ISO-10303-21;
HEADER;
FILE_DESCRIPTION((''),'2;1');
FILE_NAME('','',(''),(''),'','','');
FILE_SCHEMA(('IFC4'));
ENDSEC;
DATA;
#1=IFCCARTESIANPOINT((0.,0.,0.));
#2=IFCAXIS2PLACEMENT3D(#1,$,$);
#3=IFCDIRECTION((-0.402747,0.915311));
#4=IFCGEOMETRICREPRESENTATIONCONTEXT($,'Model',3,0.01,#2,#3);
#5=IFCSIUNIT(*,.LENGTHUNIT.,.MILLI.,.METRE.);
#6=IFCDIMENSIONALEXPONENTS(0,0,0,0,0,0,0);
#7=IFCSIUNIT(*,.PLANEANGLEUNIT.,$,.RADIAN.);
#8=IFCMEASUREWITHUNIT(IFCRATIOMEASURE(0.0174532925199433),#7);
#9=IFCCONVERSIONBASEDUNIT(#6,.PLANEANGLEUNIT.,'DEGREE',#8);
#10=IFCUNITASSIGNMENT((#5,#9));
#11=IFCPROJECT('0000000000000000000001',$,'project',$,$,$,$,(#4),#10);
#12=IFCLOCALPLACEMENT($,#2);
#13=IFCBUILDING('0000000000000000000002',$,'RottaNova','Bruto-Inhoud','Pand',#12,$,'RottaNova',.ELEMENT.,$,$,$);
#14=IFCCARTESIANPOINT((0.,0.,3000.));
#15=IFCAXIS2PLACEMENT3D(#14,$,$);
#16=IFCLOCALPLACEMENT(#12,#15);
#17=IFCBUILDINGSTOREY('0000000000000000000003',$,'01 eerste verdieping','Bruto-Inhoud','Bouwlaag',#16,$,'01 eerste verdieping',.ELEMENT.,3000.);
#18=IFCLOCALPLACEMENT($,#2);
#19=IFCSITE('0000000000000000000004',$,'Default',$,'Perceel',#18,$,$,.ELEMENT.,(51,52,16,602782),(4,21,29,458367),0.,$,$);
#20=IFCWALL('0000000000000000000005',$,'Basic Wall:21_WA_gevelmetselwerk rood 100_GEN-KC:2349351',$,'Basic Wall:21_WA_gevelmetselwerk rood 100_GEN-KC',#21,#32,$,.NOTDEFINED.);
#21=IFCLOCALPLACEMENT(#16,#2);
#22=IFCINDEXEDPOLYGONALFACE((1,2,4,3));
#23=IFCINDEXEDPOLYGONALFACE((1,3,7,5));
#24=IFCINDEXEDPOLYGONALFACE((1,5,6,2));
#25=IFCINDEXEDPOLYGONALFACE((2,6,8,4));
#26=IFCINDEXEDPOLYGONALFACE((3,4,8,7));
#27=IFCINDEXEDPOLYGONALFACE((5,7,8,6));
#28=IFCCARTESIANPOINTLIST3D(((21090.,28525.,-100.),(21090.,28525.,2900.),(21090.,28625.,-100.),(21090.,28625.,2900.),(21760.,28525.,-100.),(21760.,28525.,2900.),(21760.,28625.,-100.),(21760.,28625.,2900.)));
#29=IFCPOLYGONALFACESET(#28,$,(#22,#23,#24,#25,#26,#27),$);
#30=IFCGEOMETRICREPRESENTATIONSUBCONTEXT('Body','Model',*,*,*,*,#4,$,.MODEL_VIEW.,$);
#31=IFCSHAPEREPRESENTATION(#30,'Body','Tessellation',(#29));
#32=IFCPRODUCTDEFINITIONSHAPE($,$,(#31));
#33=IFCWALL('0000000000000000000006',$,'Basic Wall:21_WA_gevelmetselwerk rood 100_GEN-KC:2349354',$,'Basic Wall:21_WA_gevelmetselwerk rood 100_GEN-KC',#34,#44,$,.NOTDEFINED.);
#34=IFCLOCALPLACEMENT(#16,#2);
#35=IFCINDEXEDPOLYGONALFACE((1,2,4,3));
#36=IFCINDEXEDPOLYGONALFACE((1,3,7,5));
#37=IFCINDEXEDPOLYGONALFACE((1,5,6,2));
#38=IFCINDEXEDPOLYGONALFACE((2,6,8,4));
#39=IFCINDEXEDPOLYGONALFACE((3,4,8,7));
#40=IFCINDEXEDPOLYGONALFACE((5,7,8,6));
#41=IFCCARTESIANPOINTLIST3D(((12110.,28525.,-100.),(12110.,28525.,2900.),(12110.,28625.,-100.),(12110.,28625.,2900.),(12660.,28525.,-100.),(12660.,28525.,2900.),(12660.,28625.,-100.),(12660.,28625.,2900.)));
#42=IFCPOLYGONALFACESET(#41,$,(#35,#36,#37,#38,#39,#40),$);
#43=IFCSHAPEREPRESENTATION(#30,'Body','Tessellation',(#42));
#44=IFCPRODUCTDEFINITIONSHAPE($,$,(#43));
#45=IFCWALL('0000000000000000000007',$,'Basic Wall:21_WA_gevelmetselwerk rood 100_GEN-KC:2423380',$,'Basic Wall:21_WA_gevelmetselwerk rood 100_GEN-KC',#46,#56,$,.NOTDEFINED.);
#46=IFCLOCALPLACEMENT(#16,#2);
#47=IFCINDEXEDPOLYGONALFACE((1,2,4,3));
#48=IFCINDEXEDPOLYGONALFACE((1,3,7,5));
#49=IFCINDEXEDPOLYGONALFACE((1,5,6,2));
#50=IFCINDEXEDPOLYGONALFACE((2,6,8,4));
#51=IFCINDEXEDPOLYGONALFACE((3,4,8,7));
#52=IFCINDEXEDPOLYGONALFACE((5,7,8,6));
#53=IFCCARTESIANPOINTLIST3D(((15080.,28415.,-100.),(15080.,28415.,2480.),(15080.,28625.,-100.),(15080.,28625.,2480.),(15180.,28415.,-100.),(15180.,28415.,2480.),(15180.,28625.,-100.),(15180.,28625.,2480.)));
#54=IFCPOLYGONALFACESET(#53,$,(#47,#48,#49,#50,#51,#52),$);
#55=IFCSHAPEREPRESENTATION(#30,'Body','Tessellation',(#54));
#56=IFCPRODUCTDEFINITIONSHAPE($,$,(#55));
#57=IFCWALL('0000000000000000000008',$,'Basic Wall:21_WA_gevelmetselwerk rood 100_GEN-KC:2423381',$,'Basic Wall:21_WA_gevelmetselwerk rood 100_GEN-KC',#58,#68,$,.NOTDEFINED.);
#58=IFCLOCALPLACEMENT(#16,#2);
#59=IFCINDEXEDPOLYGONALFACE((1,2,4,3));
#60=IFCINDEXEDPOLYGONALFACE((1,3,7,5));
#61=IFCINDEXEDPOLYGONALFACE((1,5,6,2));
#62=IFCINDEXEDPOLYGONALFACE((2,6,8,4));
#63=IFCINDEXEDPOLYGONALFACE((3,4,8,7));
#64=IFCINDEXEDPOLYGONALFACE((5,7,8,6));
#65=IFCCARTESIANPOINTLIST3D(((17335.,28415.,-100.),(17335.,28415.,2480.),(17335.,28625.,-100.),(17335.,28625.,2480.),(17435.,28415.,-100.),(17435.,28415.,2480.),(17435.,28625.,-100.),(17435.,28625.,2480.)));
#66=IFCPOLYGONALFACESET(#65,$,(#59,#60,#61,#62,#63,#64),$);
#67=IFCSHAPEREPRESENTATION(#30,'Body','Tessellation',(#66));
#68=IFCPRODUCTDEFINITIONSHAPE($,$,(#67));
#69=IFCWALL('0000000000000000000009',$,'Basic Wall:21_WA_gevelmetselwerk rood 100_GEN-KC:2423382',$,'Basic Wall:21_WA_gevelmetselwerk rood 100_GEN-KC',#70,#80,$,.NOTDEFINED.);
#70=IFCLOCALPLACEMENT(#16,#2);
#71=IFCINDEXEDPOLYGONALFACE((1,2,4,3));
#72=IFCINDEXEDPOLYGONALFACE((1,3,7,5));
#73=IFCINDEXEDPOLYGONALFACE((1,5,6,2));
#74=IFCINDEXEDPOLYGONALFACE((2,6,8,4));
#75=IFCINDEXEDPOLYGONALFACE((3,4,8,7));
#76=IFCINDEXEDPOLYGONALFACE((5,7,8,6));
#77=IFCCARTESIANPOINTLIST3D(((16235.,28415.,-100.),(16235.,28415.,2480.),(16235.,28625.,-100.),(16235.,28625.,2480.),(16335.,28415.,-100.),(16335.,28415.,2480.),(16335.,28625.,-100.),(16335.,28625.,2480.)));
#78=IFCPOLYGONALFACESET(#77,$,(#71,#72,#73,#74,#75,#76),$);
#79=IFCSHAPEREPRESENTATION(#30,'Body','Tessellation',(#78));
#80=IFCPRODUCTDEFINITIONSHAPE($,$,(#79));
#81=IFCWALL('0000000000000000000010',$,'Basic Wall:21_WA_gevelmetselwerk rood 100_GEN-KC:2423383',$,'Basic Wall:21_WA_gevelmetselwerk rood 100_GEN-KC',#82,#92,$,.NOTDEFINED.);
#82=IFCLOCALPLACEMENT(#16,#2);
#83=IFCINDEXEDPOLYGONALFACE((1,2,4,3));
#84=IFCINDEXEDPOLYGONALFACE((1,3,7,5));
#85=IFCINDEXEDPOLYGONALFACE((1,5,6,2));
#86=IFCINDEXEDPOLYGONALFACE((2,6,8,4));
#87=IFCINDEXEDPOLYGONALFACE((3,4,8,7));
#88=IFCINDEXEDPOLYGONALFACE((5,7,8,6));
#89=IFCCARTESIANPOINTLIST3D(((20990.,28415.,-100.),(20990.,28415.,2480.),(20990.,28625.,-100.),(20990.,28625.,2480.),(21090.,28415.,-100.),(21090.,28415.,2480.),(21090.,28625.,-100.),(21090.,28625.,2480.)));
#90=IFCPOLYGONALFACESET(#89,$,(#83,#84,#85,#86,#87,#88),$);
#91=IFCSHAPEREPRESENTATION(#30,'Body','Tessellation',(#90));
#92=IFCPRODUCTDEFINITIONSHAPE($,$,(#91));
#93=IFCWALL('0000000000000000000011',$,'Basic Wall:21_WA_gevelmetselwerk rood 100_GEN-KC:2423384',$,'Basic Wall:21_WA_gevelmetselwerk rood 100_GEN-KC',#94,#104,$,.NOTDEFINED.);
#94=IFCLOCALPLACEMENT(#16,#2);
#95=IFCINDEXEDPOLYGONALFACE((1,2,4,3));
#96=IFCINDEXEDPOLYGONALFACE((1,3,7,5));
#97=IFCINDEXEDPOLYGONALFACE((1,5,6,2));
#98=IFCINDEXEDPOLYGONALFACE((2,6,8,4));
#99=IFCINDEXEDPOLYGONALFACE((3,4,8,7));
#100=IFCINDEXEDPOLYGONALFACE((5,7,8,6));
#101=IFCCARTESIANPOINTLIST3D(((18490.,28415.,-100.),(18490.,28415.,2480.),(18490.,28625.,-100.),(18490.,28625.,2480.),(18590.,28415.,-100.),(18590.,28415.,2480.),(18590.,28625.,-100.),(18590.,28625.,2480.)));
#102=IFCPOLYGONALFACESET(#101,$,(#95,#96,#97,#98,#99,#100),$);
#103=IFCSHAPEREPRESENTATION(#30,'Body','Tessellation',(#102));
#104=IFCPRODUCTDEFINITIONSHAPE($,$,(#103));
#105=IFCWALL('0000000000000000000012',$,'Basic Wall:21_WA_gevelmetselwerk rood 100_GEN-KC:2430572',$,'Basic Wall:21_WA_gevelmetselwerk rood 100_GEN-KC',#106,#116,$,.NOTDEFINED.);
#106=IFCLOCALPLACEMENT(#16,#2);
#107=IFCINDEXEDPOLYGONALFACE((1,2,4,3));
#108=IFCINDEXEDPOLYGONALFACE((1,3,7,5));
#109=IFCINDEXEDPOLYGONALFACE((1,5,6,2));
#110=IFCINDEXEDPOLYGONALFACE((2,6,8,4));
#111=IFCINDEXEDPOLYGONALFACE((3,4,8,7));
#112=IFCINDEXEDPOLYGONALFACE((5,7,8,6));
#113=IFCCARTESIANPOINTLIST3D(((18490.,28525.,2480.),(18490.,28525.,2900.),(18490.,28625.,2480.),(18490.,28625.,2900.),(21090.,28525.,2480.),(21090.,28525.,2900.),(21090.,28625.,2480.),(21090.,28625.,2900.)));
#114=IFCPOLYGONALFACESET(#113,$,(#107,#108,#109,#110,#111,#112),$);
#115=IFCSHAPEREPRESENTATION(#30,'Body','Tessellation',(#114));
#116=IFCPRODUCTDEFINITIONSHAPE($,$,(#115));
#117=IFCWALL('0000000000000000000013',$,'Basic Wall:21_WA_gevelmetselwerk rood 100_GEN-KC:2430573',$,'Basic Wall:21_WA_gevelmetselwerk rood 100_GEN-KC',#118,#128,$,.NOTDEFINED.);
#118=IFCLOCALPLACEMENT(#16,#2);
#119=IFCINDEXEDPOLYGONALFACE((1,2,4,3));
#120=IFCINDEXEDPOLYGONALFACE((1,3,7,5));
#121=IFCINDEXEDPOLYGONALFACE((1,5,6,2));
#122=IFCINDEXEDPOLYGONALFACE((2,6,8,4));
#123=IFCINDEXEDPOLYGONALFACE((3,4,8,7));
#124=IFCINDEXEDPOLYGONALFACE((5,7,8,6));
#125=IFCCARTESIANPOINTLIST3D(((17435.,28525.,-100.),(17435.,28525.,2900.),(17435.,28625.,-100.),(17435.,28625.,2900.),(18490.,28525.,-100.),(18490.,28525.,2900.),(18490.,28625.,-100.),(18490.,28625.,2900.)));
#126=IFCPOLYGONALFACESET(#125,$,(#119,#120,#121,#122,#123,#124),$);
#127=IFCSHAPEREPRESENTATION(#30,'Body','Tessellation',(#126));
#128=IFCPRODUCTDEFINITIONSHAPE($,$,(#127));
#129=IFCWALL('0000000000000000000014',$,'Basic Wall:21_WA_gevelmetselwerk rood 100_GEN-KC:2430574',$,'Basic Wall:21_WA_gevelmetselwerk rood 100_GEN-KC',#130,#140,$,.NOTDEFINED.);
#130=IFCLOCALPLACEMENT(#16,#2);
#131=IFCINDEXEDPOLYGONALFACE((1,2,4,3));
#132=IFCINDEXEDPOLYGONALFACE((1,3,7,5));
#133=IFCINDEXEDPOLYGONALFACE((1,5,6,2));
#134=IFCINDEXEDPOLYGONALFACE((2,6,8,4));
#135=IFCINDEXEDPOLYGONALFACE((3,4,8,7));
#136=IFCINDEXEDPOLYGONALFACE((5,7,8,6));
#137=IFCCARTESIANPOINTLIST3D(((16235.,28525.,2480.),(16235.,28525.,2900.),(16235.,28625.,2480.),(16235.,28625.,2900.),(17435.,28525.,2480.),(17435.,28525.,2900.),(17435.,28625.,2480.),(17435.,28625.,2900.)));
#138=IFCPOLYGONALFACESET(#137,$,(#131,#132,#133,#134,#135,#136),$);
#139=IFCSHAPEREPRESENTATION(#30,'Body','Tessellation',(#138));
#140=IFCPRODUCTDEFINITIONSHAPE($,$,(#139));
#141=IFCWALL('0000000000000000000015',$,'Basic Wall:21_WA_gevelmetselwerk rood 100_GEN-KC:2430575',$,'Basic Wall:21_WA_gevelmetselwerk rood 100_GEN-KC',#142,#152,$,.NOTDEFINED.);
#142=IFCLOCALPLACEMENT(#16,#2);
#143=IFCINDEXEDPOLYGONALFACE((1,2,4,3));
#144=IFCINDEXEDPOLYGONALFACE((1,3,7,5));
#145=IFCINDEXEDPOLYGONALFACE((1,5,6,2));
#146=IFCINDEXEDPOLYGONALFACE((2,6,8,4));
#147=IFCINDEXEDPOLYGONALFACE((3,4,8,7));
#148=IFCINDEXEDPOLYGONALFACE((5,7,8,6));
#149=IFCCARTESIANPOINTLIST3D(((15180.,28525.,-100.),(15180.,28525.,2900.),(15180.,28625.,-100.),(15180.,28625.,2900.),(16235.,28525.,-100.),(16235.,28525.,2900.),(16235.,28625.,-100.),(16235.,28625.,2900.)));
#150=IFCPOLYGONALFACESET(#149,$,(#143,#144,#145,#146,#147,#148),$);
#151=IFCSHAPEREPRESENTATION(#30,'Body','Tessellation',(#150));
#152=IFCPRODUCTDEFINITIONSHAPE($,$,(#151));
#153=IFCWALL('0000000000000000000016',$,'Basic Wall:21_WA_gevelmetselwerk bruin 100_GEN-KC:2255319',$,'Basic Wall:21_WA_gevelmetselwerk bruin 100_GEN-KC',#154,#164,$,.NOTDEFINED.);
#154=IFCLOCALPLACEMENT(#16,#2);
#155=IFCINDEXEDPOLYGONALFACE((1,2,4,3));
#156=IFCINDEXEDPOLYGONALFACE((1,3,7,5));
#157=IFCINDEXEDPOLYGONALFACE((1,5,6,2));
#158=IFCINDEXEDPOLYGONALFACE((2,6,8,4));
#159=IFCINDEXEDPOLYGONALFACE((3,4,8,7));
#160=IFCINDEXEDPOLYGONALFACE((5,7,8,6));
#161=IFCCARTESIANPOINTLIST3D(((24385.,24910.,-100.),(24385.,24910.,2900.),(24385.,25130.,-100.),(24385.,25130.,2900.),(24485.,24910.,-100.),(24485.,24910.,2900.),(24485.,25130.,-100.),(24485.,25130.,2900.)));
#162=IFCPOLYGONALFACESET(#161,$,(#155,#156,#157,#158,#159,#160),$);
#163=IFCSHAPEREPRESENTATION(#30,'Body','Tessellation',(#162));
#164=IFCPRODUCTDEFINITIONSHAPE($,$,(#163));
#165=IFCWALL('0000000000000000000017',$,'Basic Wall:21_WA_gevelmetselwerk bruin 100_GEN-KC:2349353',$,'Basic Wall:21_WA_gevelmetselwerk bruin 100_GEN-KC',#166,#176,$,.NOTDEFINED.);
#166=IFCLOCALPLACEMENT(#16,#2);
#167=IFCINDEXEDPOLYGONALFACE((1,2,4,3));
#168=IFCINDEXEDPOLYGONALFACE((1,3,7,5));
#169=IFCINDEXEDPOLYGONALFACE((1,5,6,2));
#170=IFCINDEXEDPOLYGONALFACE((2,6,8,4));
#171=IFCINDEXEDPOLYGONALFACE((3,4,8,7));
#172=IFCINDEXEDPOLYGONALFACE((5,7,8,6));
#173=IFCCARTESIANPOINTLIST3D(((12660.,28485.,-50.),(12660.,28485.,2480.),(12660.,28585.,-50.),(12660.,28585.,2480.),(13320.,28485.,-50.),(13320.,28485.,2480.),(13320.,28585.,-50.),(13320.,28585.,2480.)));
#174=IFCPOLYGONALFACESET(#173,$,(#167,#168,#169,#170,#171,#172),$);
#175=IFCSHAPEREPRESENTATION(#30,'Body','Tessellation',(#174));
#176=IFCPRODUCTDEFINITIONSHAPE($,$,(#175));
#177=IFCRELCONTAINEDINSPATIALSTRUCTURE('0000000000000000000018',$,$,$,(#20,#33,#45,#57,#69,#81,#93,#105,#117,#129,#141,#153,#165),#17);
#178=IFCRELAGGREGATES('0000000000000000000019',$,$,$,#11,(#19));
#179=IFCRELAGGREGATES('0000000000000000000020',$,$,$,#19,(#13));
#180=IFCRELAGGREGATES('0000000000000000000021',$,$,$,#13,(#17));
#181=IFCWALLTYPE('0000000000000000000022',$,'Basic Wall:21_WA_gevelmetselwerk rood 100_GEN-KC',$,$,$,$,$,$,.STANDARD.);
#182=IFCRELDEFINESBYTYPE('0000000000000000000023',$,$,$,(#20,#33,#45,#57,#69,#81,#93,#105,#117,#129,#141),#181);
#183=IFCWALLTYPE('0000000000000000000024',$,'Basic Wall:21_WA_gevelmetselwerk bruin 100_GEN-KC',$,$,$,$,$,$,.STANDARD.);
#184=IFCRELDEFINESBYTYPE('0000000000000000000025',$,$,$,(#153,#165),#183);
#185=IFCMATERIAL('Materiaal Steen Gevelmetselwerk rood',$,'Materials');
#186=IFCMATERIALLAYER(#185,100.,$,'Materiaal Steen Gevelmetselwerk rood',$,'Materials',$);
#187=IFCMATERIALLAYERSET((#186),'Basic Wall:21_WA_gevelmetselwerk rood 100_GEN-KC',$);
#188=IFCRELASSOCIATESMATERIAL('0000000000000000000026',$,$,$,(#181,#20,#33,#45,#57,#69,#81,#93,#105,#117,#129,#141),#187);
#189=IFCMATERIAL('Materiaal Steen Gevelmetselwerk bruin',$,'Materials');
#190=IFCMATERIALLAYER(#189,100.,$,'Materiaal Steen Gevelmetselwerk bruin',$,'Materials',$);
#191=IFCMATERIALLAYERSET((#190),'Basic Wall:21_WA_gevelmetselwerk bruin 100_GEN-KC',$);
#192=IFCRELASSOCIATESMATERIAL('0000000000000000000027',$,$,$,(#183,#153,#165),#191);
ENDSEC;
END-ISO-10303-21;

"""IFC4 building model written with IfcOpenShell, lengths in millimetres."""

from ifc_helpers import new_model, entity, si_unit, converted_unit, direction, frame, frame_2d, origin, place, context, subcontext, project, spatial, polyline, rectangle, extrude, clip, bounded_halfspace, material, layer, layer_set, type_object, element, save


model = new_model("IFC4")

# Units and contexts
model_context = context("Model", 3, precision=0.01, world=origin(), true_north=direction((-0.402747, 0.915311)))
body_context = subcontext(model_context, "Body", "Model", "MODEL_VIEW")
ifc_project = project(units=[si_unit("LENGTHUNIT", "METRE", prefix="MILLI"), converted_unit("PLANEANGLEUNIT", "DEGREE", entity("IfcRatioMeasure", 0.0174532925199433), si_unit("PLANEANGLEUNIT", "RADIAN"), dimensions=[0, 0, 0, 0, 0, 0, 0])], contexts=[model_context])

# Site, building, storey
site_placement = place(None, origin())
site = spatial("IfcSite", under=ifc_project, at=site_placement, Name="Default", ObjectType="Perceel", CompositionType="ELEMENT", RefLatitude=(51, 52, 16, 602782), RefLongitude=(4, 21, 29, 458367), RefElevation=0.0)
building_placement = place(None, origin())
building = spatial("IfcBuilding", under=site, at=building_placement, Name="RottaNova", Description="Bruto-Inhoud", ObjectType="Pand", LongName="RottaNova", CompositionType="ELEMENT")
storey_placement = place(building_placement, frame((0.0, 0.0, 3000.0)))
storey = spatial("IfcBuildingStorey", under=building, at=storey_placement, Name="01 eerste verdieping", Description="Bruto-Inhoud", ObjectType="Bouwlaag", LongName="01 eerste verdieping", CompositionType="ELEMENT", Elevation=3000.0)

# Walls
ifc_material_1 = material(Name="Materiaal Steen Gevelmetselwerk rood", Category="Materials")
ifc_layer_1 = layer(ifc_material_1, 100.0, Name="Materiaal Steen Gevelmetselwerk rood", Category="Materials")
ifc_layer_set_1 = layer_set([ifc_layer_1], Name="Basic Wall:21_WA_gevelmetselwerk rood 100_GEN-KC")
wall_type_1 = type_object("IfcWallType", Name="Basic Wall:21_WA_gevelmetselwerk rood 100_GEN-KC", PredefinedType="STANDARD", material=ifc_layer_set_1)
wall_1_placement = place(storey_placement, frame((21760.0, 28575.0, -100.0), z_axis=(0.0, 0.0, 1.0), x_axis=(-1.0, 0.0, 0.0)))
element("IfcWall", 1, at=wall_1_placement, inside=storey, type_object=wall_type_1, material=ifc_layer_set_1, Name="Basic Wall:21_WA_gevelmetselwerk rood 100_GEN-KC:2349351", ObjectType="Basic Wall:21_WA_gevelmetselwerk rood 100_GEN-KC", PredefinedType="NOTDEFINED", context=body_context, shape_type="SweptSolid", body=[
    extrude(rectangle(XDim=670.0, YDim=100.0, at=frame_2d((335.0, 0.0), x_axis=(-1.0, 0.0))), origin(), (0.0, 0.0, 1.0), 3000.0),
])
wall_2_placement = place(storey_placement, frame((12660.0, 28575.0, -100.0), z_axis=(0.0, 0.0, 1.0), x_axis=(-1.0, 0.0, 0.0)))
element("IfcWall", 2, at=wall_2_placement, inside=storey, type_object=wall_type_1, material=ifc_layer_set_1, Name="Basic Wall:21_WA_gevelmetselwerk rood 100_GEN-KC:2349354", ObjectType="Basic Wall:21_WA_gevelmetselwerk rood 100_GEN-KC", PredefinedType="NOTDEFINED", context=body_context, shape_type="SweptSolid", body=[
    extrude(rectangle(XDim=550.0, YDim=100.0, at=frame_2d((275.0, 0.0), x_axis=(-1.0, 0.0))), origin(), (0.0, 0.0, 1.0), 3000.0),
])
wall_3_placement = place(storey_placement, frame((15130.0, 28415.0, -100.0), z_axis=(0.0, 0.0, 1.0), x_axis=(0.0, 1.0, 0.0)))
element("IfcWall", 3, at=wall_3_placement, inside=storey, type_object=wall_type_1, material=ifc_layer_set_1, Name="Basic Wall:21_WA_gevelmetselwerk rood 100_GEN-KC:2423380", ObjectType="Basic Wall:21_WA_gevelmetselwerk rood 100_GEN-KC", PredefinedType="NOTDEFINED", context=body_context, shape_type="SweptSolid", body=[
    extrude(rectangle(XDim=210.0, YDim=100.0, at=frame_2d((105.0, 0.0), x_axis=(-1.0, 0.0))), origin(), (0.0, 0.0, 1.0), 2580.0),
])
for number, where, z_axis, x_axis, name in (
    (4, (17385.0, 28415.0, -100.0), (0.0, 0.0, 1.0), (0.0, 1.0, 0.0), "Basic Wall:21_WA_gevelmetselwerk rood 100_GEN-KC:2423381"),
    (5, (16285.0, 28415.0, -100.0), (0.0, 0.0, 1.0), (0.0, 1.0, 0.0), "Basic Wall:21_WA_gevelmetselwerk rood 100_GEN-KC:2423382"),
):
    element("IfcWall", number, at=place(storey_placement, frame(where, z_axis=z_axis, x_axis=x_axis)), inside=storey, type_object=wall_type_1, material=ifc_layer_set_1, Name=name, ObjectType="Basic Wall:21_WA_gevelmetselwerk rood 100_GEN-KC", PredefinedType="NOTDEFINED", context=body_context, shape_type="SweptSolid", body=[
        extrude(rectangle(XDim=210.0, YDim=100.0, at=frame_2d((105.0, 0.0), x_axis=(-1.0, 0.0))), origin(), (0.0, 0.0, 1.0), 2580.0),
    ])
wall_4_placement = place(storey_placement, frame((21040.0, 28415.0, -100.0), z_axis=(0.0, 0.0, 1.0), x_axis=(0.0, 1.0, 0.0)))
element("IfcWall", 6, at=wall_4_placement, inside=storey, type_object=wall_type_1, material=ifc_layer_set_1, Name="Basic Wall:21_WA_gevelmetselwerk rood 100_GEN-KC:2423383", ObjectType="Basic Wall:21_WA_gevelmetselwerk rood 100_GEN-KC", PredefinedType="NOTDEFINED", context=body_context, shape_type="SweptSolid", body=[
    extrude(rectangle(XDim=210.0, YDim=100.0, at=frame_2d((105.0, 0.0), x_axis=(-1.0, 0.0))), origin(), (0.0, 0.0, 1.0), 2580.0),
])
wall_5_placement = place(storey_placement, frame((18540.0, 28415.0, -100.0), z_axis=(0.0, 0.0, 1.0), x_axis=(0.0, 1.0, 0.0)))
element("IfcWall", 7, at=wall_5_placement, inside=storey, type_object=wall_type_1, material=ifc_layer_set_1, Name="Basic Wall:21_WA_gevelmetselwerk rood 100_GEN-KC:2423384", ObjectType="Basic Wall:21_WA_gevelmetselwerk rood 100_GEN-KC", PredefinedType="NOTDEFINED", context=body_context, shape_type="SweptSolid", body=[
    extrude(rectangle(XDim=210.0, YDim=100.0, at=frame_2d((105.0, 0.0), x_axis=(-1.0, 0.0))), origin(), (0.0, 0.0, 1.0), 2580.0),
])
wall_6_placement = place(storey_placement, frame((21090.0, 28575.0, 2480.0), z_axis=(0.0, 0.0, 1.0), x_axis=(-1.0, 0.0, 0.0)))
element("IfcWall", 8, at=wall_6_placement, inside=storey, type_object=wall_type_1, material=ifc_layer_set_1, Name="Basic Wall:21_WA_gevelmetselwerk rood 100_GEN-KC:2430572", ObjectType="Basic Wall:21_WA_gevelmetselwerk rood 100_GEN-KC", PredefinedType="NOTDEFINED", context=body_context, shape_type="Clipping", body=[
    clip(extrude(rectangle(XDim=2600.0, YDim=100.0, at=frame_2d((1300.0, 0.0), x_axis=(-1.0, 0.0))), origin(), (0.0, 0.0, 1.0), 420.0), bounded_halfspace(frame((2600.0, -50.0, 420.0), z_axis=(1.0, 0.0, 0.0), x_axis=(0.0, 1.0, 0.0)), False, frame((2600.0, -50.0, 420.0), z_axis=(1.0, 0.0, 0.0), x_axis=(0.0, 1.0, 0.0)), polyline([(0.0, 0.0), (0.0, -128016.0), (30480.0, -128016.0), (30480.0, 0.0), (0.0, 0.0)]))),
])
wall_7_placement = place(storey_placement, frame((18490.0, 28575.0, -100.0), z_axis=(0.0, 0.0, 1.0), x_axis=(-1.0, 0.0, 0.0)))
element("IfcWall", 9, at=wall_7_placement, inside=storey, type_object=wall_type_1, material=ifc_layer_set_1, Name="Basic Wall:21_WA_gevelmetselwerk rood 100_GEN-KC:2430573", ObjectType="Basic Wall:21_WA_gevelmetselwerk rood 100_GEN-KC", PredefinedType="NOTDEFINED", context=body_context, shape_type="SweptSolid", body=[
    extrude(rectangle(XDim=1055.0, YDim=100.0, at=frame_2d((527.5, 0.0), x_axis=(-1.0, 0.0))), origin(), (0.0, 0.0, 1.0), 3000.0),
])
wall_8_placement = place(storey_placement, frame((17435.0, 28575.0, 2480.0), z_axis=(0.0, 0.0, 1.0), x_axis=(-1.0, 0.0, 0.0)))
element("IfcWall", 10, at=wall_8_placement, inside=storey, type_object=wall_type_1, material=ifc_layer_set_1, Name="Basic Wall:21_WA_gevelmetselwerk rood 100_GEN-KC:2430574", ObjectType="Basic Wall:21_WA_gevelmetselwerk rood 100_GEN-KC", PredefinedType="NOTDEFINED", context=body_context, shape_type="SweptSolid", body=[
    extrude(rectangle(XDim=1200.0, YDim=100.0, at=frame_2d((600.0, 0.0), x_axis=(-1.0, 0.0))), origin(), (0.0, 0.0, 1.0), 420.0),
])
wall_9_placement = place(storey_placement, frame((16235.0, 28575.0, -100.0), z_axis=(0.0, 0.0, 1.0), x_axis=(-1.0, 0.0, 0.0)))
element("IfcWall", 11, at=wall_9_placement, inside=storey, type_object=wall_type_1, material=ifc_layer_set_1, Name="Basic Wall:21_WA_gevelmetselwerk rood 100_GEN-KC:2430575", ObjectType="Basic Wall:21_WA_gevelmetselwerk rood 100_GEN-KC", PredefinedType="NOTDEFINED", context=body_context, shape_type="SweptSolid", body=[
    extrude(rectangle(XDim=1055.0, YDim=100.0, at=frame_2d((527.5, 0.0), x_axis=(-1.0, 0.0))), origin(), (0.0, 0.0, 1.0), 3000.0),
])
ifc_material_2 = material(Name="Materiaal Steen Gevelmetselwerk bruin", Category="Materials")
ifc_layer_2 = layer(ifc_material_2, 100.0, Name="Materiaal Steen Gevelmetselwerk bruin", Category="Materials")
ifc_layer_set_2 = layer_set([ifc_layer_2], Name="Basic Wall:21_WA_gevelmetselwerk bruin 100_GEN-KC")
wall_type_2 = type_object("IfcWallType", Name="Basic Wall:21_WA_gevelmetselwerk bruin 100_GEN-KC", PredefinedType="STANDARD", material=ifc_layer_set_2)
wall_10_placement = place(storey_placement, frame((24435.0, 25130.0, -100.0), z_axis=(0.0, 0.0, 1.0), x_axis=(0.0, -1.0, 0.0)))
element("IfcWall", 12, at=wall_10_placement, inside=storey, type_object=wall_type_2, material=ifc_layer_set_2, Name="Basic Wall:21_WA_gevelmetselwerk bruin 100_GEN-KC:2255319", ObjectType="Basic Wall:21_WA_gevelmetselwerk bruin 100_GEN-KC", PredefinedType="NOTDEFINED", context=body_context, shape_type="SweptSolid", body=[
    extrude(rectangle(XDim=220.0, YDim=100.0, at=frame_2d((110.0, 0.0), x_axis=(-1.0, 0.0))), origin(), (0.0, 0.0, 1.0), 3000.0),
])
wall_11_placement = place(storey_placement, frame((12660.0, 28535.0, -50.0)))
element("IfcWall", 13, at=wall_11_placement, inside=storey, type_object=wall_type_2, material=ifc_layer_set_2, Name="Basic Wall:21_WA_gevelmetselwerk bruin 100_GEN-KC:2349353", ObjectType="Basic Wall:21_WA_gevelmetselwerk bruin 100_GEN-KC", PredefinedType="NOTDEFINED", context=body_context, shape_type="SweptSolid", body=[
    extrude(rectangle(XDim=660.0, YDim=100.0, at=frame_2d((330.0, 0.0), x_axis=(-1.0, 0.0))), origin(), (0.0, 0.0, 1.0), 2530.0),
])

save(model, "model.ifc")
